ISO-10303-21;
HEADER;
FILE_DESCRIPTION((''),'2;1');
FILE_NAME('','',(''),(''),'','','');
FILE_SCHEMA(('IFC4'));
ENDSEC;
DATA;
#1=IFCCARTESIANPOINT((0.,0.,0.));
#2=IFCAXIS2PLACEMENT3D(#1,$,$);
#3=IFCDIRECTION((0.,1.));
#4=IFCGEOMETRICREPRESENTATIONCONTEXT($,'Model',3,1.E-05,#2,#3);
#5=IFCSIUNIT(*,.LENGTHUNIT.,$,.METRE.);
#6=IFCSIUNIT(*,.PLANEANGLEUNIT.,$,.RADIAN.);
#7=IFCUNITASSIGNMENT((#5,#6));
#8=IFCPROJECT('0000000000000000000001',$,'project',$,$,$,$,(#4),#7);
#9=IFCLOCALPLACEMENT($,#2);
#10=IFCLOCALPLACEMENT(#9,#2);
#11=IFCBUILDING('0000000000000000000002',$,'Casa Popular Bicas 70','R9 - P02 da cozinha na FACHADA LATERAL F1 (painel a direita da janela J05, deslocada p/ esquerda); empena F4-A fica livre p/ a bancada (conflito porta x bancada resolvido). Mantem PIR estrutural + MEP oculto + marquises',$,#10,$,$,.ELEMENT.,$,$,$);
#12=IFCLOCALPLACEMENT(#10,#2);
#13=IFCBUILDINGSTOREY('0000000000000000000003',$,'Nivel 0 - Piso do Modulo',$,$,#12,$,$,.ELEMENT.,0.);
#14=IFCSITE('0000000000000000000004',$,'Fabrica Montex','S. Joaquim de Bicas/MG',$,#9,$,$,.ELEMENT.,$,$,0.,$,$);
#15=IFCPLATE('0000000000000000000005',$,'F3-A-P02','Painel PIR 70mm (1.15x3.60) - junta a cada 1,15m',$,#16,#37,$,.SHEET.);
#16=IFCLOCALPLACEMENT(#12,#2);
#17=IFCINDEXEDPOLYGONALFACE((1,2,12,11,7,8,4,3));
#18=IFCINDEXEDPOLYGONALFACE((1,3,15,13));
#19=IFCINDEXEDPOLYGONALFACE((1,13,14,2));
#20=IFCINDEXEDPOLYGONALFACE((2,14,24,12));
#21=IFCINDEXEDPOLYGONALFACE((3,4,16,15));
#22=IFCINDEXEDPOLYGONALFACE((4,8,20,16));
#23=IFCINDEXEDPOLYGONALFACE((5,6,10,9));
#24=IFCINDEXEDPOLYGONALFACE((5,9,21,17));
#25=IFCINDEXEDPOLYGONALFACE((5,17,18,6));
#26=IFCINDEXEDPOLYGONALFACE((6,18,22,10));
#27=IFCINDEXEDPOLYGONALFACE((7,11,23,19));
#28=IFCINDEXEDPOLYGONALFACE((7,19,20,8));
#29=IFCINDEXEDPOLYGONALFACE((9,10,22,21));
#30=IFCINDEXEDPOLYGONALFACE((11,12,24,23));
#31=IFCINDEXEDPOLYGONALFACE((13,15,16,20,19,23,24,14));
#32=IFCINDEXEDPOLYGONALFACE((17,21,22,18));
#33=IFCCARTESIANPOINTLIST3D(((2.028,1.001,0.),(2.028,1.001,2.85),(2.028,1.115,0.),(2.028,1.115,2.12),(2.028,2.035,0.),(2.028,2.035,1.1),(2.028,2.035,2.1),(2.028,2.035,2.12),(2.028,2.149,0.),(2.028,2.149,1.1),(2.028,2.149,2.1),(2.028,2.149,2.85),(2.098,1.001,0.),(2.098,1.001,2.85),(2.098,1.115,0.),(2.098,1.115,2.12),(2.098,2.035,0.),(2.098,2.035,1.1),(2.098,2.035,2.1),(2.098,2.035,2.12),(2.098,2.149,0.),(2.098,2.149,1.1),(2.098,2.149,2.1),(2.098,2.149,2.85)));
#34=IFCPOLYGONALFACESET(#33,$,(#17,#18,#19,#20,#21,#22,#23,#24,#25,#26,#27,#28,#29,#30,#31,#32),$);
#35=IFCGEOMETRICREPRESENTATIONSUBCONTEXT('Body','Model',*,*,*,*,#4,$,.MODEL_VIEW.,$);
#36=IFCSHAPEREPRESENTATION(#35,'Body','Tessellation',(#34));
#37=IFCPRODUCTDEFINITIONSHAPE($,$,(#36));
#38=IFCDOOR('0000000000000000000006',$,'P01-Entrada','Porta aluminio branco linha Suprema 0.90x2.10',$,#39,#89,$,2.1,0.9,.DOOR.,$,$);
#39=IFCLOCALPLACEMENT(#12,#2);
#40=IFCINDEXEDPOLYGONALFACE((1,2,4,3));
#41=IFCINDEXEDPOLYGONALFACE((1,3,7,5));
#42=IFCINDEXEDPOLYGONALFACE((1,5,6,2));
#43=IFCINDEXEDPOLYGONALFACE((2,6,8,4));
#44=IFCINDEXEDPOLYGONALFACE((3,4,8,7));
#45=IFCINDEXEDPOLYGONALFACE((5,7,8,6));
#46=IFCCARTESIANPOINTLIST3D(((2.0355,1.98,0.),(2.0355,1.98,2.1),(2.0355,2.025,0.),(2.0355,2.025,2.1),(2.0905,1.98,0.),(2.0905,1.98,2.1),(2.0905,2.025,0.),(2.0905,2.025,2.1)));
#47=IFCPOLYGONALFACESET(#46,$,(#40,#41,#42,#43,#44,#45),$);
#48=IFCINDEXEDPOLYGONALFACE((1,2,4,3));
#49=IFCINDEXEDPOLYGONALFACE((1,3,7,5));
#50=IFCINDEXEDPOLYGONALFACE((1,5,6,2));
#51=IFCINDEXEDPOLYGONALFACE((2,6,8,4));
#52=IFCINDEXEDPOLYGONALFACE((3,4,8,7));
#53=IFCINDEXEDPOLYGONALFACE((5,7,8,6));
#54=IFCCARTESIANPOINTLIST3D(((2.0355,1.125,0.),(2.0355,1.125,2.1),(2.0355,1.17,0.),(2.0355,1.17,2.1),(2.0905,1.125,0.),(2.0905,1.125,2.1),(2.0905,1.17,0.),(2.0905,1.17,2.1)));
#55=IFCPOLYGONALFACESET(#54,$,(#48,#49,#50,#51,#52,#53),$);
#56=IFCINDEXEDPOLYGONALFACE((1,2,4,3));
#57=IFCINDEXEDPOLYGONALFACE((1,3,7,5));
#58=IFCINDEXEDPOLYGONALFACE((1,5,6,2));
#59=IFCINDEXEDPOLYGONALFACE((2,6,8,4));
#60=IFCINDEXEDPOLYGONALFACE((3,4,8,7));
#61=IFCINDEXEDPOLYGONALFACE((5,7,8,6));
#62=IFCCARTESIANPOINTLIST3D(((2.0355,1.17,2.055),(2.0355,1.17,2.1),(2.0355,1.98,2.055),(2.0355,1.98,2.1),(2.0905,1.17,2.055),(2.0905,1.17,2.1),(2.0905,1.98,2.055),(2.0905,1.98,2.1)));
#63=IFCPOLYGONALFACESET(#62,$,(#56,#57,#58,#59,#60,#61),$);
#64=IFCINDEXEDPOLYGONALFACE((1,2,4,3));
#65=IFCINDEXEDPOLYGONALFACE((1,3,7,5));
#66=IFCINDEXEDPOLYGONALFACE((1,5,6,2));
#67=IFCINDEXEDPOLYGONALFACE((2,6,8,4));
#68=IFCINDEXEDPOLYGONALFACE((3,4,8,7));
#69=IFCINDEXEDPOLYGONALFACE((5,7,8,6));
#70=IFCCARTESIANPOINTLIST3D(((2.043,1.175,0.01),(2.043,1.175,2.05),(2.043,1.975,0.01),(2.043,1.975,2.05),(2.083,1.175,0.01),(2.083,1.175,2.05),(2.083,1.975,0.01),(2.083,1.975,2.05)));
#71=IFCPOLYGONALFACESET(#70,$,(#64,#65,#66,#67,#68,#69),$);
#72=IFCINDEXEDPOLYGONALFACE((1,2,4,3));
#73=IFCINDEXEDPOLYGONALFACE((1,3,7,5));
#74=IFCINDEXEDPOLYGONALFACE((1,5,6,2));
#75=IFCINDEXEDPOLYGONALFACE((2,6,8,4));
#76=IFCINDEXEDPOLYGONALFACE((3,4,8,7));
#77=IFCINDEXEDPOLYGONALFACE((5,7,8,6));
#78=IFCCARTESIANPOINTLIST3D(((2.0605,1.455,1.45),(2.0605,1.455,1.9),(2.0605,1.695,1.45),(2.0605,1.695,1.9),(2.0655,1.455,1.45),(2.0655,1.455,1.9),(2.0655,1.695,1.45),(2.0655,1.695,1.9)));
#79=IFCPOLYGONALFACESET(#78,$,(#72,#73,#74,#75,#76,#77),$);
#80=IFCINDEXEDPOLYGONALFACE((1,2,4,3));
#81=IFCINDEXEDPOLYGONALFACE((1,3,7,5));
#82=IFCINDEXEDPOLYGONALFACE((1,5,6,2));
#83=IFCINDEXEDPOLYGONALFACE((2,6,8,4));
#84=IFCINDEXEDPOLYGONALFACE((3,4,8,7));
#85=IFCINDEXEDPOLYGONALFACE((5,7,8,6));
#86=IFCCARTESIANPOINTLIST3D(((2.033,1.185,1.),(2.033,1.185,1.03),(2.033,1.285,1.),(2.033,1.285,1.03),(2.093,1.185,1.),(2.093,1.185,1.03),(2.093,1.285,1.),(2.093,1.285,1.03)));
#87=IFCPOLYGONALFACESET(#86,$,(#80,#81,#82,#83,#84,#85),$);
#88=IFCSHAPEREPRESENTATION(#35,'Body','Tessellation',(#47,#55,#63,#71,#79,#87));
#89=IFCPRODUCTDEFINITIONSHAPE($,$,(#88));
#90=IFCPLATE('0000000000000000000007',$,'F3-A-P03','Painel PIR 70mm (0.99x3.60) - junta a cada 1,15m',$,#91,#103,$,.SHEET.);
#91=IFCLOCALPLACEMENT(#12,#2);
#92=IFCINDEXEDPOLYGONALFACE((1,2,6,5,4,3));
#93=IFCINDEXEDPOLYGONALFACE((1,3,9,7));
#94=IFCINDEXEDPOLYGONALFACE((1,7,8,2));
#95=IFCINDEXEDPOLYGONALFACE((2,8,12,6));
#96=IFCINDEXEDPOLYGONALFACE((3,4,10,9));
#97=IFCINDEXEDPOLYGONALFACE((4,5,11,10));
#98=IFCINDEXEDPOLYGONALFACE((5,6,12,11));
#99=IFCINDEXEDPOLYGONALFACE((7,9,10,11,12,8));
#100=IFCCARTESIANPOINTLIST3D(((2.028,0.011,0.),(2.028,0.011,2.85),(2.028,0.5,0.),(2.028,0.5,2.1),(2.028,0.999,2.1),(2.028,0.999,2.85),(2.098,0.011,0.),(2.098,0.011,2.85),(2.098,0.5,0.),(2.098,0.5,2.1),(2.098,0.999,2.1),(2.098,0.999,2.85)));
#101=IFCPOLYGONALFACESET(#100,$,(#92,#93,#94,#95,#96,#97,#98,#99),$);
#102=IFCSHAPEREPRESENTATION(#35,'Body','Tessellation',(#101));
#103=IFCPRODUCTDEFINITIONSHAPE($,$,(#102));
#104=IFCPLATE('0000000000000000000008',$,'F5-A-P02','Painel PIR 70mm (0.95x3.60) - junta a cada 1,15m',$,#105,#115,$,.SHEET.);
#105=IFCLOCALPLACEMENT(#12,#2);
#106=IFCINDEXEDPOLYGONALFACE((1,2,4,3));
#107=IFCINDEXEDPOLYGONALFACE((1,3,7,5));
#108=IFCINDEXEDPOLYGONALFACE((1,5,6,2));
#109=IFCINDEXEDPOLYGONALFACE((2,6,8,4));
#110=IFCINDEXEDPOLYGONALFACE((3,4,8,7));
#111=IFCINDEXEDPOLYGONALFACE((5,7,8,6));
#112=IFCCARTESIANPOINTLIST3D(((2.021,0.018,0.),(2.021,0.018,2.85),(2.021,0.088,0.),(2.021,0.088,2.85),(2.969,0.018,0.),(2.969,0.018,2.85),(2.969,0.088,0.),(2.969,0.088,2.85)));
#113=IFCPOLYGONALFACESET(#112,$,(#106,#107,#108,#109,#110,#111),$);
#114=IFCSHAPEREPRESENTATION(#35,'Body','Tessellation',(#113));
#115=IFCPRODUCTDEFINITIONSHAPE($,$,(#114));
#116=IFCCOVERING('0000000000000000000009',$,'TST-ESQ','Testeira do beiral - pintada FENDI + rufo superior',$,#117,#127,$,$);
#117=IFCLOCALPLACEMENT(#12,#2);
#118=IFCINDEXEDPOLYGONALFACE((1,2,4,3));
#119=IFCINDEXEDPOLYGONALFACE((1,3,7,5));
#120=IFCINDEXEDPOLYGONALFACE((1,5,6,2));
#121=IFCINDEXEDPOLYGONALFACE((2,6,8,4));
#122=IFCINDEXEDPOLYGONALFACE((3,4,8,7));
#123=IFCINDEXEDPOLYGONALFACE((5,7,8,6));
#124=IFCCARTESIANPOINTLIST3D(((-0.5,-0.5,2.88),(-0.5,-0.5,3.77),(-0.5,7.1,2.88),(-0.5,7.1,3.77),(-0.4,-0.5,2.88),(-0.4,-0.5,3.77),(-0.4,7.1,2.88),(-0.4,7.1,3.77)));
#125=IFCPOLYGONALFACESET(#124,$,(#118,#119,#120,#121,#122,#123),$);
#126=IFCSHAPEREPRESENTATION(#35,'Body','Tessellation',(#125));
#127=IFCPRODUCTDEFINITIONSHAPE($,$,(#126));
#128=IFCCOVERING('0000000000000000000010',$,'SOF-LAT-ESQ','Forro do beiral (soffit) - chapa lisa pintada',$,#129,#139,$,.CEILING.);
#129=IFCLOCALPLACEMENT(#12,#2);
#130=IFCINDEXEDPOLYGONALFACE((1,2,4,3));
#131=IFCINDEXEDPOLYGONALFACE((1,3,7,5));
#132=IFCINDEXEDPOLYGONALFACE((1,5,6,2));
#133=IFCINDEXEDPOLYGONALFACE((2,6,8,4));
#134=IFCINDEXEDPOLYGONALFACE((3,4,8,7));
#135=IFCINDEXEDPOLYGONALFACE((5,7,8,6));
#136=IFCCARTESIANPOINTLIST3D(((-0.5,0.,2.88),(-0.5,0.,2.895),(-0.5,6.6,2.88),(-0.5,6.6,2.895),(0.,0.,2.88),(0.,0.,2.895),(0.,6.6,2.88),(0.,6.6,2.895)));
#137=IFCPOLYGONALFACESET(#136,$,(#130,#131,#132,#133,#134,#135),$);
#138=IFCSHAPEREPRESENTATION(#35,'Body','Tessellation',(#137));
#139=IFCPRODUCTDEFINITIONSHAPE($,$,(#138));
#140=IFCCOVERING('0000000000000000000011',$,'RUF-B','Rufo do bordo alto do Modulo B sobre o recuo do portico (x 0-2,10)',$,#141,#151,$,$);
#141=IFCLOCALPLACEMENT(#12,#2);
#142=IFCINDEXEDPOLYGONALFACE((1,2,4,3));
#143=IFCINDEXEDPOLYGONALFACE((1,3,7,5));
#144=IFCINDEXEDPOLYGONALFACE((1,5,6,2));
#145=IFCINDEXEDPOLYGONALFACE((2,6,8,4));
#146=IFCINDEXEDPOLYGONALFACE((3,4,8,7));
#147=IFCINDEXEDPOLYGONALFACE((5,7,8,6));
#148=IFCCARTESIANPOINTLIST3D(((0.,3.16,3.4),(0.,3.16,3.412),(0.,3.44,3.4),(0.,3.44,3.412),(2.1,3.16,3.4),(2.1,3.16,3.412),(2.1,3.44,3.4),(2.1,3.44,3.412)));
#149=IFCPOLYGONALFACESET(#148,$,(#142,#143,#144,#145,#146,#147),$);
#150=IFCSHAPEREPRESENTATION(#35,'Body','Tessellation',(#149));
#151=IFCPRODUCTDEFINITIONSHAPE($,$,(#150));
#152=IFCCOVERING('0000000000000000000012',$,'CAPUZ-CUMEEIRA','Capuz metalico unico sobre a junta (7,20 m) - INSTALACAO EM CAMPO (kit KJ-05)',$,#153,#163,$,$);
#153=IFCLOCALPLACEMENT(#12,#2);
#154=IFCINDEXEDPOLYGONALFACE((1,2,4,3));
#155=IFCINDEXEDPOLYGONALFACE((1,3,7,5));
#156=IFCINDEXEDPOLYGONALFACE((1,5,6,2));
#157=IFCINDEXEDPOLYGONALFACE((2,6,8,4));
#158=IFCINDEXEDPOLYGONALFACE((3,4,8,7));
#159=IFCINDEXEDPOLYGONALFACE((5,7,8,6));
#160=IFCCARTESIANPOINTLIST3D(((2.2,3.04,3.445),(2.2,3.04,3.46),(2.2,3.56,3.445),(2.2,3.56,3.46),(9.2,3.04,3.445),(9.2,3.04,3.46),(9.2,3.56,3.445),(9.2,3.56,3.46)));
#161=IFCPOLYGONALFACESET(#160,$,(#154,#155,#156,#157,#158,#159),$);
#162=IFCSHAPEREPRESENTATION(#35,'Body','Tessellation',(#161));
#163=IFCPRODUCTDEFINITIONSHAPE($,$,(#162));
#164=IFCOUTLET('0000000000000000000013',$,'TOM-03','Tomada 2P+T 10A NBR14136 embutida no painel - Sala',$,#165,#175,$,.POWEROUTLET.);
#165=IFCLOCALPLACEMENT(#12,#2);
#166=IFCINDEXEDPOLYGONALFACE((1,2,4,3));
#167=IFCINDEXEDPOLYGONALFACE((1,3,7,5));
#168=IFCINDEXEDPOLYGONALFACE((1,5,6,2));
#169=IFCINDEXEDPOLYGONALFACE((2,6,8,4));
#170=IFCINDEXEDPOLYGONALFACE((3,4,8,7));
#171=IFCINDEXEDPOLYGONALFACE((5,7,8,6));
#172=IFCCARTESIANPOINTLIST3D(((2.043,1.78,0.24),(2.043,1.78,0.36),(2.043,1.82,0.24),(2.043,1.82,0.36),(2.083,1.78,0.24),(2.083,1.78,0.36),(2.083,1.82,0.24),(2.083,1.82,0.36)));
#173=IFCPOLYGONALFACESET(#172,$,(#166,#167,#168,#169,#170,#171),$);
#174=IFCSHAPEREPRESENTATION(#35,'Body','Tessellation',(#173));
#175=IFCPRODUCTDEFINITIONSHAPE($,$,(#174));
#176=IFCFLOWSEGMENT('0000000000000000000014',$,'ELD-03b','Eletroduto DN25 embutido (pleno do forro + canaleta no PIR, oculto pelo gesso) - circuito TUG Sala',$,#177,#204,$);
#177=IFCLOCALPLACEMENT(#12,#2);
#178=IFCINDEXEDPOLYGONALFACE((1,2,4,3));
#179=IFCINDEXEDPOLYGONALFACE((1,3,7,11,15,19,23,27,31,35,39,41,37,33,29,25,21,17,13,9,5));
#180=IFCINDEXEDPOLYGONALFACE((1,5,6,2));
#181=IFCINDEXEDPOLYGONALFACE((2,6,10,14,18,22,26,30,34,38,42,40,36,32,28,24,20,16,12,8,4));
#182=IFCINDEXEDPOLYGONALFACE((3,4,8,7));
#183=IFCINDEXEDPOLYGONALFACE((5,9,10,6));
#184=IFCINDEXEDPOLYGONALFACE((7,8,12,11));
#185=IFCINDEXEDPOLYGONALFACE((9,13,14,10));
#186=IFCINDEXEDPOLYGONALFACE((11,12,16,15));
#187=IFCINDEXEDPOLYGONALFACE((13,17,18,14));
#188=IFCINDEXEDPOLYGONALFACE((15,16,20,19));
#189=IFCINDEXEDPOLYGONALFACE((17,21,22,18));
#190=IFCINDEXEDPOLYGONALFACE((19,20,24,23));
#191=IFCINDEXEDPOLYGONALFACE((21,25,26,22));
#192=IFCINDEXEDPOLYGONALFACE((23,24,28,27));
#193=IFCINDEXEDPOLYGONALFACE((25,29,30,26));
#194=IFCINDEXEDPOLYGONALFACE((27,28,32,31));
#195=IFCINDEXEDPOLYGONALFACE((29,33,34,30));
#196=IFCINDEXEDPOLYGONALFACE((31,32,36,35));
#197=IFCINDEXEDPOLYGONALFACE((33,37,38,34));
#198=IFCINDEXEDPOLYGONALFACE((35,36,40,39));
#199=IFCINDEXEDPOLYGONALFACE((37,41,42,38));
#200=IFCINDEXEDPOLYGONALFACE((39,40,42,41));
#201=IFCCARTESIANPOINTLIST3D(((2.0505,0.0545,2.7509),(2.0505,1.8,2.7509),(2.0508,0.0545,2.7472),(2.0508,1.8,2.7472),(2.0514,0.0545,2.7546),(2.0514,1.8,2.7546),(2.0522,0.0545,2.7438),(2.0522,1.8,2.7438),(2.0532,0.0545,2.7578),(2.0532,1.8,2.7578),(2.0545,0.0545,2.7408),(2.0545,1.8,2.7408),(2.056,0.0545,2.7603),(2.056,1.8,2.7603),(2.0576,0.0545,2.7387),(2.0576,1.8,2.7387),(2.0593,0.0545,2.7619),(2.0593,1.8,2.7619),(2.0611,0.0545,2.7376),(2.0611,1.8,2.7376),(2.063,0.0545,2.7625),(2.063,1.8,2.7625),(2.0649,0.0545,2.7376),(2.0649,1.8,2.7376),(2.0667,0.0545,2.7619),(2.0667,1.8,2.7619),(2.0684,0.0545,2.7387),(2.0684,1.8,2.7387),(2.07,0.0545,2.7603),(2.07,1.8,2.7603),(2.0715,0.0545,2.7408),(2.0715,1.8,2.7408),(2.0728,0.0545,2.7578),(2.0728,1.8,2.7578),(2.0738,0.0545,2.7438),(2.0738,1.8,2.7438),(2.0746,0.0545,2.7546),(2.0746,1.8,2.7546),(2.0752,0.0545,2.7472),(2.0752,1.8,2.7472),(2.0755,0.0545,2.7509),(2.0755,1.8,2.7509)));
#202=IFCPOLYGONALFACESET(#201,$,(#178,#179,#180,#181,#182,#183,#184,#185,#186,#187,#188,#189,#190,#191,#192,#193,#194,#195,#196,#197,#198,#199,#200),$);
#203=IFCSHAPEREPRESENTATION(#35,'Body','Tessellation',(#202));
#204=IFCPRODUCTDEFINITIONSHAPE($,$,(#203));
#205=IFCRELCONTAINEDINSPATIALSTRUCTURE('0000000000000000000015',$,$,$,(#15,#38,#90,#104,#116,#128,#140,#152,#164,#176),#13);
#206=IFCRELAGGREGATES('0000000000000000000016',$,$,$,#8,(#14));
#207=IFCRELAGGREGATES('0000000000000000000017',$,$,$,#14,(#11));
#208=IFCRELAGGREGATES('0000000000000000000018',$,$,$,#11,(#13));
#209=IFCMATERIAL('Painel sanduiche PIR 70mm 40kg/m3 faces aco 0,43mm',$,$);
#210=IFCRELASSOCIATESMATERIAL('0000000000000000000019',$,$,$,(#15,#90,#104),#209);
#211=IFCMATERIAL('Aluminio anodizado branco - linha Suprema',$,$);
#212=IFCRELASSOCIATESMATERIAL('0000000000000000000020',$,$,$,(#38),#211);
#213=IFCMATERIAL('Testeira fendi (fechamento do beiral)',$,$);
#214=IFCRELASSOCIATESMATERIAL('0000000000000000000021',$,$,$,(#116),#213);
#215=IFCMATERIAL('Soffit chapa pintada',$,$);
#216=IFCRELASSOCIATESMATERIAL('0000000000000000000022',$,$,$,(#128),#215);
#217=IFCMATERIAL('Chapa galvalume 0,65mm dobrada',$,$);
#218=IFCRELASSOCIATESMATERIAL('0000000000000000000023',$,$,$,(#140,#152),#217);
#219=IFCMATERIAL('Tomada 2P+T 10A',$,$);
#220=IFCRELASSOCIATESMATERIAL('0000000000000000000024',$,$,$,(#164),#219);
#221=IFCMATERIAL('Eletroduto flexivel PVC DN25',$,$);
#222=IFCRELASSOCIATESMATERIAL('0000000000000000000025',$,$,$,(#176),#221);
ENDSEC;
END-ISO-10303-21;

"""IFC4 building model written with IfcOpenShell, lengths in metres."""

from ifc_helpers import new_model, si_unit, direction, frame, frame_2d, origin, origin_2d, place, context, subcontext, project, spatial, rectangle, circle, extrude, material, element, fill, save


model = new_model("IFC4")

# Units and contexts
model_context = context("Model", 3, precision=1e-05, world=origin(), true_north=direction((0.0, 1.0)))
body_context = subcontext(model_context, "Body", "Model", "MODEL_VIEW")
ifc_project = project(units=[si_unit("LENGTHUNIT", "METRE"), si_unit("PLANEANGLEUNIT", "RADIAN")], contexts=[model_context])

# Site, building, storey
site_placement = place(None, origin())
site = spatial("IfcSite", under=ifc_project, at=site_placement, Name="Fabrica Montex", Description="S. Joaquim de Bicas/MG", CompositionType="ELEMENT", RefElevation=0.0)
building_placement = place(site_placement, origin())
building = spatial("IfcBuilding", under=site, at=building_placement, Name="Casa Popular Bicas 70", Description="R9 - P02 da cozinha na FACHADA LATERAL F1 (painel a direita da janela J05, deslocada p/ esquerda); empena F4-A fica livre p/ a bancada (conflito porta x bancada resolvido). Mantem PIR estrutural + MEP oculto + marquises", CompositionType="ELEMENT")
storey_placement = place(building_placement, origin())
storey = spatial("IfcBuildingStorey", under=building, at=storey_placement, Name="Nivel 0 - Piso do Modulo", CompositionType="ELEMENT", Elevation=0.0)

# Shared definitions
ifc_material_1 = material(Name="Aluminio anodizado branco - linha Suprema")

# Plate, openings, door
ifc_material_2 = material(Name="Painel sanduiche PIR 70mm 40kg/m3 faces aco 0,43mm")
plate_1_placement = place(None, frame((2.063, 2.149, 0.0), z_axis=(0.0, 0.0, 1.0), x_axis=(0.0, -1.0, 0.0)))
plate_1 = element("IfcPlate", 1, at=plate_1_placement, inside=storey, material=ifc_material_2, Name="F3-A-P02", Description="Painel PIR 70mm (1.15x3.60) - junta a cada 1,15m", PredefinedType="SHEET", context=body_context, shape_type="SweptSolid", body=[
    extrude(rectangle(XDim=1.148, YDim=0.07, at=frame_2d((0.574, 0.0))), origin(), (0.0, 0.0, 1.0), 2.85),
])
opening_1_placement = place(None, frame((2.063, 1.95, 1.1), z_axis=(0.0, 0.0, 1.0), x_axis=(-1.0, 0.0, 0.0)))
element("IfcOpeningElement", 2, at=opening_1_placement, cuts=plate_1, PredefinedType="OPENING", context=body_context, shape_type="SweptSolid", body=[
    extrude(rectangle(XDim=0.1, YDim=0.4, at=origin_2d()), origin(), (0.0, 0.0, 1.0), 1.0),
])
opening_2_placement = place(None, frame((2.063, 2.025, 0.0), z_axis=(0.0, 0.0, 1.0), x_axis=(0.0, -1.0, 0.0)))
opening_2 = element("IfcOpeningElement", 3, at=opening_2_placement, cuts=plate_1, PredefinedType="OPENING", context=body_context, shape_type="SweptSolid", body=[
    extrude(rectangle(XDim=0.92, YDim=0.3, at=frame_2d((0.45, 0.0))), origin(), (0.0, 0.0, 1.0), 2.12),
])
door_placement = place(None, frame((2.063, 2.025, 0.0), z_axis=(0.0, 0.0, 1.0), x_axis=(0.0, -1.0, 0.0)))
door = element("IfcDoor", 4, at=door_placement, inside=storey, material=ifc_material_1, Name="P01-Entrada", Description="Porta aluminio branco linha Suprema 0.90x2.10", OverallHeight=2.1, OverallWidth=0.9, PredefinedType="DOOR", context=body_context, shape_type="SweptSolid", body=[
    extrude(rectangle(XDim=0.045, YDim=0.055, at=frame_2d((0.0225, 0.0))), origin(), (0.0, 0.0, 1.0), 2.1),
    extrude(rectangle(XDim=0.045, YDim=0.055, at=frame_2d((0.8775, 0.0))), origin(), (0.0, 0.0, 1.0), 2.1),
    extrude(rectangle(XDim=0.81, YDim=0.055, at=frame_2d((0.45, 0.0))), frame((0.0, 0.0, 2.055)), (0.0, 0.0, 1.0), 0.045),
    extrude(rectangle(XDim=0.8, YDim=0.04, at=frame_2d((0.45, 0.0))), frame((0.0, 0.0, 0.01)), (0.0, 0.0, 1.0), 2.04),
    extrude(rectangle(XDim=0.24, YDim=0.005, at=frame_2d((0.45, 0.0))), frame((0.0, 0.0, 1.45)), (0.0, 0.0, 1.0), 0.45),
    extrude(rectangle(XDim=0.1, YDim=0.06, at=frame_2d((0.79, 0.0))), frame((0.0, 0.0, 1.0)), (0.0, 0.0, 1.0), 0.03),
])
fill(opening_2, door)

# Plate, opening
plate_2_placement = place(None, frame((2.063, 0.999, 0.0), z_axis=(0.0, 0.0, 1.0), x_axis=(0.0, -1.0, 0.0)))
plate_2 = element("IfcPlate", 5, at=plate_2_placement, inside=storey, material=ifc_material_2, Name="F3-A-P03", Description="Painel PIR 70mm (0.99x3.60) - junta a cada 1,15m", PredefinedType="SHEET", context=body_context, shape_type="SweptSolid", body=[
    extrude(rectangle(XDim=0.988, YDim=0.07, at=frame_2d((0.494, 0.0))), origin(), (0.0, 0.0, 1.0), 2.85),
])
opening_3_placement = place(None, frame((2.063, 0.75, 0.0), z_axis=(0.0, 0.0, 1.0), x_axis=(-1.0, 0.0, 0.0)))
element("IfcOpeningElement", 6, at=opening_3_placement, cuts=plate_2, PredefinedType="OPENING", context=body_context, shape_type="SweptSolid", body=[
    extrude(rectangle(XDim=0.1, YDim=0.5, at=origin_2d()), origin(), (0.0, 0.0, 1.0), 2.1),
])

# Plate
plate_3_placement = place(None, frame((2.969, 0.053, 0.0), z_axis=(0.0, 0.0, 1.0), x_axis=(-1.0, 0.0, 0.0)))
element("IfcPlate", 7, at=plate_3_placement, inside=storey, material=ifc_material_2, Name="F5-A-P02", Description="Painel PIR 70mm (0.95x3.60) - junta a cada 1,15m", PredefinedType="SHEET", context=body_context, shape_type="SweptSolid", body=[
    extrude(rectangle(XDim=0.948, YDim=0.07, at=frame_2d((0.474, 0.0))), origin(), (0.0, 0.0, 1.0), 2.85),
])

# Coverings
ifc_material_3 = material(Name="Testeira fendi (fechamento do beiral)")
covering_1_placement = place(storey_placement, frame((-0.45, -0.5, 2.88), x_axis=(0.0, 1.0, 0.0)))
element("IfcCovering", 8, at=covering_1_placement, inside=storey, material=ifc_material_3, Name="TST-ESQ", Description="Testeira do beiral - pintada FENDI + rufo superior", context=body_context, shape_type="SweptSolid", body=[
    extrude(rectangle(XDim=7.6, YDim=0.1, at=frame_2d((3.8, 0.0))), origin(), (0.0, 0.0, 1.0), 0.89),
])
ifc_material_4 = material(Name="Soffit chapa pintada")
covering_2_placement = place(storey_placement, frame((-0.5, 0.0, 2.88)))
element("IfcCovering", 9, at=covering_2_placement, inside=storey, material=ifc_material_4, Name="SOF-LAT-ESQ", Description="Forro do beiral (soffit) - chapa lisa pintada", PredefinedType="CEILING", context=body_context, shape_type="SweptSolid", body=[
    extrude(rectangle(XDim=0.5, YDim=6.6, at=frame_2d((0.25, 3.3))), origin(), (0.0, 0.0, 1.0), 0.015),
])
ifc_material_5 = material(Name="Chapa galvalume 0,65mm dobrada")
covering_3_placement = place(storey_placement, frame((0.0, 3.16, 3.4), x_axis=(1.0, 0.0, 0.0)))
element("IfcCovering", 10, at=covering_3_placement, inside=storey, material=ifc_material_5, Name="RUF-B", Description="Rufo do bordo alto do Modulo B sobre o recuo do portico (x 0-2,10)", context=body_context, shape_type="SweptSolid", body=[
    extrude(rectangle(XDim=2.1, YDim=0.28, at=frame_2d((1.05, 0.14))), origin(), (0.0, 0.0, 1.0), 0.012),
])
covering_4_placement = place(storey_placement, frame((2.2, 3.04, 3.445), x_axis=(1.0, 0.0, 0.0)))
element("IfcCovering", 11, at=covering_4_placement, inside=storey, material=ifc_material_5, Name="CAPUZ-CUMEEIRA", Description="Capuz metalico unico sobre a junta (7,20 m) - INSTALACAO EM CAMPO (kit KJ-05)", context=body_context, shape_type="SweptSolid", body=[
    extrude(rectangle(XDim=7.0, YDim=0.52, at=frame_2d((3.5, 0.26))), origin(), (0.0, 0.0, 1.0), 0.015),
])

# Outlet
ifc_material_6 = material(Name="Tomada 2P+T 10A")
outlet_placement = place(None, frame((2.083, 1.82, 0.24), z_axis=(0.0, 0.0, 1.0), x_axis=(-1.0, 0.0, 0.0)))
element("IfcOutlet", 12, at=outlet_placement, inside=storey, material=ifc_material_6, Name="TOM-03", Description="Tomada 2P+T 10A NBR14136 embutida no painel - Sala", PredefinedType="POWEROUTLET", context=body_context, shape_type="SweptSolid", body=[
    extrude(rectangle(XDim=0.04, YDim=0.04, at=frame_2d((0.02, 0.02))), origin(), (0.0, 0.0, 1.0), 0.12),
])

# Flow segment
ifc_material_7 = material(Name="Eletroduto flexivel PVC DN25")
flow_segment_1_placement = place(None, frame((2.063, 0.0545, 2.75), z_axis=(0.0, 1.0, 0.0), x_axis=(0.0, 0.0, 1.0)))
element("IfcFlowSegment", 13, at=flow_segment_1_placement, inside=storey, material=ifc_material_7, Name="ELD-03b", Description="Eletroduto DN25 embutido (pleno do forro + canaleta no PIR, oculto pelo gesso) - circuito TUG Sala", context=body_context, shape_type="SweptSolid", body=[
    extrude(circle(Radius=0.0125, at=origin_2d()), origin(), (0.0, 0.0, 1.0), 1.7455),
])

save(model, "model.ifc")
